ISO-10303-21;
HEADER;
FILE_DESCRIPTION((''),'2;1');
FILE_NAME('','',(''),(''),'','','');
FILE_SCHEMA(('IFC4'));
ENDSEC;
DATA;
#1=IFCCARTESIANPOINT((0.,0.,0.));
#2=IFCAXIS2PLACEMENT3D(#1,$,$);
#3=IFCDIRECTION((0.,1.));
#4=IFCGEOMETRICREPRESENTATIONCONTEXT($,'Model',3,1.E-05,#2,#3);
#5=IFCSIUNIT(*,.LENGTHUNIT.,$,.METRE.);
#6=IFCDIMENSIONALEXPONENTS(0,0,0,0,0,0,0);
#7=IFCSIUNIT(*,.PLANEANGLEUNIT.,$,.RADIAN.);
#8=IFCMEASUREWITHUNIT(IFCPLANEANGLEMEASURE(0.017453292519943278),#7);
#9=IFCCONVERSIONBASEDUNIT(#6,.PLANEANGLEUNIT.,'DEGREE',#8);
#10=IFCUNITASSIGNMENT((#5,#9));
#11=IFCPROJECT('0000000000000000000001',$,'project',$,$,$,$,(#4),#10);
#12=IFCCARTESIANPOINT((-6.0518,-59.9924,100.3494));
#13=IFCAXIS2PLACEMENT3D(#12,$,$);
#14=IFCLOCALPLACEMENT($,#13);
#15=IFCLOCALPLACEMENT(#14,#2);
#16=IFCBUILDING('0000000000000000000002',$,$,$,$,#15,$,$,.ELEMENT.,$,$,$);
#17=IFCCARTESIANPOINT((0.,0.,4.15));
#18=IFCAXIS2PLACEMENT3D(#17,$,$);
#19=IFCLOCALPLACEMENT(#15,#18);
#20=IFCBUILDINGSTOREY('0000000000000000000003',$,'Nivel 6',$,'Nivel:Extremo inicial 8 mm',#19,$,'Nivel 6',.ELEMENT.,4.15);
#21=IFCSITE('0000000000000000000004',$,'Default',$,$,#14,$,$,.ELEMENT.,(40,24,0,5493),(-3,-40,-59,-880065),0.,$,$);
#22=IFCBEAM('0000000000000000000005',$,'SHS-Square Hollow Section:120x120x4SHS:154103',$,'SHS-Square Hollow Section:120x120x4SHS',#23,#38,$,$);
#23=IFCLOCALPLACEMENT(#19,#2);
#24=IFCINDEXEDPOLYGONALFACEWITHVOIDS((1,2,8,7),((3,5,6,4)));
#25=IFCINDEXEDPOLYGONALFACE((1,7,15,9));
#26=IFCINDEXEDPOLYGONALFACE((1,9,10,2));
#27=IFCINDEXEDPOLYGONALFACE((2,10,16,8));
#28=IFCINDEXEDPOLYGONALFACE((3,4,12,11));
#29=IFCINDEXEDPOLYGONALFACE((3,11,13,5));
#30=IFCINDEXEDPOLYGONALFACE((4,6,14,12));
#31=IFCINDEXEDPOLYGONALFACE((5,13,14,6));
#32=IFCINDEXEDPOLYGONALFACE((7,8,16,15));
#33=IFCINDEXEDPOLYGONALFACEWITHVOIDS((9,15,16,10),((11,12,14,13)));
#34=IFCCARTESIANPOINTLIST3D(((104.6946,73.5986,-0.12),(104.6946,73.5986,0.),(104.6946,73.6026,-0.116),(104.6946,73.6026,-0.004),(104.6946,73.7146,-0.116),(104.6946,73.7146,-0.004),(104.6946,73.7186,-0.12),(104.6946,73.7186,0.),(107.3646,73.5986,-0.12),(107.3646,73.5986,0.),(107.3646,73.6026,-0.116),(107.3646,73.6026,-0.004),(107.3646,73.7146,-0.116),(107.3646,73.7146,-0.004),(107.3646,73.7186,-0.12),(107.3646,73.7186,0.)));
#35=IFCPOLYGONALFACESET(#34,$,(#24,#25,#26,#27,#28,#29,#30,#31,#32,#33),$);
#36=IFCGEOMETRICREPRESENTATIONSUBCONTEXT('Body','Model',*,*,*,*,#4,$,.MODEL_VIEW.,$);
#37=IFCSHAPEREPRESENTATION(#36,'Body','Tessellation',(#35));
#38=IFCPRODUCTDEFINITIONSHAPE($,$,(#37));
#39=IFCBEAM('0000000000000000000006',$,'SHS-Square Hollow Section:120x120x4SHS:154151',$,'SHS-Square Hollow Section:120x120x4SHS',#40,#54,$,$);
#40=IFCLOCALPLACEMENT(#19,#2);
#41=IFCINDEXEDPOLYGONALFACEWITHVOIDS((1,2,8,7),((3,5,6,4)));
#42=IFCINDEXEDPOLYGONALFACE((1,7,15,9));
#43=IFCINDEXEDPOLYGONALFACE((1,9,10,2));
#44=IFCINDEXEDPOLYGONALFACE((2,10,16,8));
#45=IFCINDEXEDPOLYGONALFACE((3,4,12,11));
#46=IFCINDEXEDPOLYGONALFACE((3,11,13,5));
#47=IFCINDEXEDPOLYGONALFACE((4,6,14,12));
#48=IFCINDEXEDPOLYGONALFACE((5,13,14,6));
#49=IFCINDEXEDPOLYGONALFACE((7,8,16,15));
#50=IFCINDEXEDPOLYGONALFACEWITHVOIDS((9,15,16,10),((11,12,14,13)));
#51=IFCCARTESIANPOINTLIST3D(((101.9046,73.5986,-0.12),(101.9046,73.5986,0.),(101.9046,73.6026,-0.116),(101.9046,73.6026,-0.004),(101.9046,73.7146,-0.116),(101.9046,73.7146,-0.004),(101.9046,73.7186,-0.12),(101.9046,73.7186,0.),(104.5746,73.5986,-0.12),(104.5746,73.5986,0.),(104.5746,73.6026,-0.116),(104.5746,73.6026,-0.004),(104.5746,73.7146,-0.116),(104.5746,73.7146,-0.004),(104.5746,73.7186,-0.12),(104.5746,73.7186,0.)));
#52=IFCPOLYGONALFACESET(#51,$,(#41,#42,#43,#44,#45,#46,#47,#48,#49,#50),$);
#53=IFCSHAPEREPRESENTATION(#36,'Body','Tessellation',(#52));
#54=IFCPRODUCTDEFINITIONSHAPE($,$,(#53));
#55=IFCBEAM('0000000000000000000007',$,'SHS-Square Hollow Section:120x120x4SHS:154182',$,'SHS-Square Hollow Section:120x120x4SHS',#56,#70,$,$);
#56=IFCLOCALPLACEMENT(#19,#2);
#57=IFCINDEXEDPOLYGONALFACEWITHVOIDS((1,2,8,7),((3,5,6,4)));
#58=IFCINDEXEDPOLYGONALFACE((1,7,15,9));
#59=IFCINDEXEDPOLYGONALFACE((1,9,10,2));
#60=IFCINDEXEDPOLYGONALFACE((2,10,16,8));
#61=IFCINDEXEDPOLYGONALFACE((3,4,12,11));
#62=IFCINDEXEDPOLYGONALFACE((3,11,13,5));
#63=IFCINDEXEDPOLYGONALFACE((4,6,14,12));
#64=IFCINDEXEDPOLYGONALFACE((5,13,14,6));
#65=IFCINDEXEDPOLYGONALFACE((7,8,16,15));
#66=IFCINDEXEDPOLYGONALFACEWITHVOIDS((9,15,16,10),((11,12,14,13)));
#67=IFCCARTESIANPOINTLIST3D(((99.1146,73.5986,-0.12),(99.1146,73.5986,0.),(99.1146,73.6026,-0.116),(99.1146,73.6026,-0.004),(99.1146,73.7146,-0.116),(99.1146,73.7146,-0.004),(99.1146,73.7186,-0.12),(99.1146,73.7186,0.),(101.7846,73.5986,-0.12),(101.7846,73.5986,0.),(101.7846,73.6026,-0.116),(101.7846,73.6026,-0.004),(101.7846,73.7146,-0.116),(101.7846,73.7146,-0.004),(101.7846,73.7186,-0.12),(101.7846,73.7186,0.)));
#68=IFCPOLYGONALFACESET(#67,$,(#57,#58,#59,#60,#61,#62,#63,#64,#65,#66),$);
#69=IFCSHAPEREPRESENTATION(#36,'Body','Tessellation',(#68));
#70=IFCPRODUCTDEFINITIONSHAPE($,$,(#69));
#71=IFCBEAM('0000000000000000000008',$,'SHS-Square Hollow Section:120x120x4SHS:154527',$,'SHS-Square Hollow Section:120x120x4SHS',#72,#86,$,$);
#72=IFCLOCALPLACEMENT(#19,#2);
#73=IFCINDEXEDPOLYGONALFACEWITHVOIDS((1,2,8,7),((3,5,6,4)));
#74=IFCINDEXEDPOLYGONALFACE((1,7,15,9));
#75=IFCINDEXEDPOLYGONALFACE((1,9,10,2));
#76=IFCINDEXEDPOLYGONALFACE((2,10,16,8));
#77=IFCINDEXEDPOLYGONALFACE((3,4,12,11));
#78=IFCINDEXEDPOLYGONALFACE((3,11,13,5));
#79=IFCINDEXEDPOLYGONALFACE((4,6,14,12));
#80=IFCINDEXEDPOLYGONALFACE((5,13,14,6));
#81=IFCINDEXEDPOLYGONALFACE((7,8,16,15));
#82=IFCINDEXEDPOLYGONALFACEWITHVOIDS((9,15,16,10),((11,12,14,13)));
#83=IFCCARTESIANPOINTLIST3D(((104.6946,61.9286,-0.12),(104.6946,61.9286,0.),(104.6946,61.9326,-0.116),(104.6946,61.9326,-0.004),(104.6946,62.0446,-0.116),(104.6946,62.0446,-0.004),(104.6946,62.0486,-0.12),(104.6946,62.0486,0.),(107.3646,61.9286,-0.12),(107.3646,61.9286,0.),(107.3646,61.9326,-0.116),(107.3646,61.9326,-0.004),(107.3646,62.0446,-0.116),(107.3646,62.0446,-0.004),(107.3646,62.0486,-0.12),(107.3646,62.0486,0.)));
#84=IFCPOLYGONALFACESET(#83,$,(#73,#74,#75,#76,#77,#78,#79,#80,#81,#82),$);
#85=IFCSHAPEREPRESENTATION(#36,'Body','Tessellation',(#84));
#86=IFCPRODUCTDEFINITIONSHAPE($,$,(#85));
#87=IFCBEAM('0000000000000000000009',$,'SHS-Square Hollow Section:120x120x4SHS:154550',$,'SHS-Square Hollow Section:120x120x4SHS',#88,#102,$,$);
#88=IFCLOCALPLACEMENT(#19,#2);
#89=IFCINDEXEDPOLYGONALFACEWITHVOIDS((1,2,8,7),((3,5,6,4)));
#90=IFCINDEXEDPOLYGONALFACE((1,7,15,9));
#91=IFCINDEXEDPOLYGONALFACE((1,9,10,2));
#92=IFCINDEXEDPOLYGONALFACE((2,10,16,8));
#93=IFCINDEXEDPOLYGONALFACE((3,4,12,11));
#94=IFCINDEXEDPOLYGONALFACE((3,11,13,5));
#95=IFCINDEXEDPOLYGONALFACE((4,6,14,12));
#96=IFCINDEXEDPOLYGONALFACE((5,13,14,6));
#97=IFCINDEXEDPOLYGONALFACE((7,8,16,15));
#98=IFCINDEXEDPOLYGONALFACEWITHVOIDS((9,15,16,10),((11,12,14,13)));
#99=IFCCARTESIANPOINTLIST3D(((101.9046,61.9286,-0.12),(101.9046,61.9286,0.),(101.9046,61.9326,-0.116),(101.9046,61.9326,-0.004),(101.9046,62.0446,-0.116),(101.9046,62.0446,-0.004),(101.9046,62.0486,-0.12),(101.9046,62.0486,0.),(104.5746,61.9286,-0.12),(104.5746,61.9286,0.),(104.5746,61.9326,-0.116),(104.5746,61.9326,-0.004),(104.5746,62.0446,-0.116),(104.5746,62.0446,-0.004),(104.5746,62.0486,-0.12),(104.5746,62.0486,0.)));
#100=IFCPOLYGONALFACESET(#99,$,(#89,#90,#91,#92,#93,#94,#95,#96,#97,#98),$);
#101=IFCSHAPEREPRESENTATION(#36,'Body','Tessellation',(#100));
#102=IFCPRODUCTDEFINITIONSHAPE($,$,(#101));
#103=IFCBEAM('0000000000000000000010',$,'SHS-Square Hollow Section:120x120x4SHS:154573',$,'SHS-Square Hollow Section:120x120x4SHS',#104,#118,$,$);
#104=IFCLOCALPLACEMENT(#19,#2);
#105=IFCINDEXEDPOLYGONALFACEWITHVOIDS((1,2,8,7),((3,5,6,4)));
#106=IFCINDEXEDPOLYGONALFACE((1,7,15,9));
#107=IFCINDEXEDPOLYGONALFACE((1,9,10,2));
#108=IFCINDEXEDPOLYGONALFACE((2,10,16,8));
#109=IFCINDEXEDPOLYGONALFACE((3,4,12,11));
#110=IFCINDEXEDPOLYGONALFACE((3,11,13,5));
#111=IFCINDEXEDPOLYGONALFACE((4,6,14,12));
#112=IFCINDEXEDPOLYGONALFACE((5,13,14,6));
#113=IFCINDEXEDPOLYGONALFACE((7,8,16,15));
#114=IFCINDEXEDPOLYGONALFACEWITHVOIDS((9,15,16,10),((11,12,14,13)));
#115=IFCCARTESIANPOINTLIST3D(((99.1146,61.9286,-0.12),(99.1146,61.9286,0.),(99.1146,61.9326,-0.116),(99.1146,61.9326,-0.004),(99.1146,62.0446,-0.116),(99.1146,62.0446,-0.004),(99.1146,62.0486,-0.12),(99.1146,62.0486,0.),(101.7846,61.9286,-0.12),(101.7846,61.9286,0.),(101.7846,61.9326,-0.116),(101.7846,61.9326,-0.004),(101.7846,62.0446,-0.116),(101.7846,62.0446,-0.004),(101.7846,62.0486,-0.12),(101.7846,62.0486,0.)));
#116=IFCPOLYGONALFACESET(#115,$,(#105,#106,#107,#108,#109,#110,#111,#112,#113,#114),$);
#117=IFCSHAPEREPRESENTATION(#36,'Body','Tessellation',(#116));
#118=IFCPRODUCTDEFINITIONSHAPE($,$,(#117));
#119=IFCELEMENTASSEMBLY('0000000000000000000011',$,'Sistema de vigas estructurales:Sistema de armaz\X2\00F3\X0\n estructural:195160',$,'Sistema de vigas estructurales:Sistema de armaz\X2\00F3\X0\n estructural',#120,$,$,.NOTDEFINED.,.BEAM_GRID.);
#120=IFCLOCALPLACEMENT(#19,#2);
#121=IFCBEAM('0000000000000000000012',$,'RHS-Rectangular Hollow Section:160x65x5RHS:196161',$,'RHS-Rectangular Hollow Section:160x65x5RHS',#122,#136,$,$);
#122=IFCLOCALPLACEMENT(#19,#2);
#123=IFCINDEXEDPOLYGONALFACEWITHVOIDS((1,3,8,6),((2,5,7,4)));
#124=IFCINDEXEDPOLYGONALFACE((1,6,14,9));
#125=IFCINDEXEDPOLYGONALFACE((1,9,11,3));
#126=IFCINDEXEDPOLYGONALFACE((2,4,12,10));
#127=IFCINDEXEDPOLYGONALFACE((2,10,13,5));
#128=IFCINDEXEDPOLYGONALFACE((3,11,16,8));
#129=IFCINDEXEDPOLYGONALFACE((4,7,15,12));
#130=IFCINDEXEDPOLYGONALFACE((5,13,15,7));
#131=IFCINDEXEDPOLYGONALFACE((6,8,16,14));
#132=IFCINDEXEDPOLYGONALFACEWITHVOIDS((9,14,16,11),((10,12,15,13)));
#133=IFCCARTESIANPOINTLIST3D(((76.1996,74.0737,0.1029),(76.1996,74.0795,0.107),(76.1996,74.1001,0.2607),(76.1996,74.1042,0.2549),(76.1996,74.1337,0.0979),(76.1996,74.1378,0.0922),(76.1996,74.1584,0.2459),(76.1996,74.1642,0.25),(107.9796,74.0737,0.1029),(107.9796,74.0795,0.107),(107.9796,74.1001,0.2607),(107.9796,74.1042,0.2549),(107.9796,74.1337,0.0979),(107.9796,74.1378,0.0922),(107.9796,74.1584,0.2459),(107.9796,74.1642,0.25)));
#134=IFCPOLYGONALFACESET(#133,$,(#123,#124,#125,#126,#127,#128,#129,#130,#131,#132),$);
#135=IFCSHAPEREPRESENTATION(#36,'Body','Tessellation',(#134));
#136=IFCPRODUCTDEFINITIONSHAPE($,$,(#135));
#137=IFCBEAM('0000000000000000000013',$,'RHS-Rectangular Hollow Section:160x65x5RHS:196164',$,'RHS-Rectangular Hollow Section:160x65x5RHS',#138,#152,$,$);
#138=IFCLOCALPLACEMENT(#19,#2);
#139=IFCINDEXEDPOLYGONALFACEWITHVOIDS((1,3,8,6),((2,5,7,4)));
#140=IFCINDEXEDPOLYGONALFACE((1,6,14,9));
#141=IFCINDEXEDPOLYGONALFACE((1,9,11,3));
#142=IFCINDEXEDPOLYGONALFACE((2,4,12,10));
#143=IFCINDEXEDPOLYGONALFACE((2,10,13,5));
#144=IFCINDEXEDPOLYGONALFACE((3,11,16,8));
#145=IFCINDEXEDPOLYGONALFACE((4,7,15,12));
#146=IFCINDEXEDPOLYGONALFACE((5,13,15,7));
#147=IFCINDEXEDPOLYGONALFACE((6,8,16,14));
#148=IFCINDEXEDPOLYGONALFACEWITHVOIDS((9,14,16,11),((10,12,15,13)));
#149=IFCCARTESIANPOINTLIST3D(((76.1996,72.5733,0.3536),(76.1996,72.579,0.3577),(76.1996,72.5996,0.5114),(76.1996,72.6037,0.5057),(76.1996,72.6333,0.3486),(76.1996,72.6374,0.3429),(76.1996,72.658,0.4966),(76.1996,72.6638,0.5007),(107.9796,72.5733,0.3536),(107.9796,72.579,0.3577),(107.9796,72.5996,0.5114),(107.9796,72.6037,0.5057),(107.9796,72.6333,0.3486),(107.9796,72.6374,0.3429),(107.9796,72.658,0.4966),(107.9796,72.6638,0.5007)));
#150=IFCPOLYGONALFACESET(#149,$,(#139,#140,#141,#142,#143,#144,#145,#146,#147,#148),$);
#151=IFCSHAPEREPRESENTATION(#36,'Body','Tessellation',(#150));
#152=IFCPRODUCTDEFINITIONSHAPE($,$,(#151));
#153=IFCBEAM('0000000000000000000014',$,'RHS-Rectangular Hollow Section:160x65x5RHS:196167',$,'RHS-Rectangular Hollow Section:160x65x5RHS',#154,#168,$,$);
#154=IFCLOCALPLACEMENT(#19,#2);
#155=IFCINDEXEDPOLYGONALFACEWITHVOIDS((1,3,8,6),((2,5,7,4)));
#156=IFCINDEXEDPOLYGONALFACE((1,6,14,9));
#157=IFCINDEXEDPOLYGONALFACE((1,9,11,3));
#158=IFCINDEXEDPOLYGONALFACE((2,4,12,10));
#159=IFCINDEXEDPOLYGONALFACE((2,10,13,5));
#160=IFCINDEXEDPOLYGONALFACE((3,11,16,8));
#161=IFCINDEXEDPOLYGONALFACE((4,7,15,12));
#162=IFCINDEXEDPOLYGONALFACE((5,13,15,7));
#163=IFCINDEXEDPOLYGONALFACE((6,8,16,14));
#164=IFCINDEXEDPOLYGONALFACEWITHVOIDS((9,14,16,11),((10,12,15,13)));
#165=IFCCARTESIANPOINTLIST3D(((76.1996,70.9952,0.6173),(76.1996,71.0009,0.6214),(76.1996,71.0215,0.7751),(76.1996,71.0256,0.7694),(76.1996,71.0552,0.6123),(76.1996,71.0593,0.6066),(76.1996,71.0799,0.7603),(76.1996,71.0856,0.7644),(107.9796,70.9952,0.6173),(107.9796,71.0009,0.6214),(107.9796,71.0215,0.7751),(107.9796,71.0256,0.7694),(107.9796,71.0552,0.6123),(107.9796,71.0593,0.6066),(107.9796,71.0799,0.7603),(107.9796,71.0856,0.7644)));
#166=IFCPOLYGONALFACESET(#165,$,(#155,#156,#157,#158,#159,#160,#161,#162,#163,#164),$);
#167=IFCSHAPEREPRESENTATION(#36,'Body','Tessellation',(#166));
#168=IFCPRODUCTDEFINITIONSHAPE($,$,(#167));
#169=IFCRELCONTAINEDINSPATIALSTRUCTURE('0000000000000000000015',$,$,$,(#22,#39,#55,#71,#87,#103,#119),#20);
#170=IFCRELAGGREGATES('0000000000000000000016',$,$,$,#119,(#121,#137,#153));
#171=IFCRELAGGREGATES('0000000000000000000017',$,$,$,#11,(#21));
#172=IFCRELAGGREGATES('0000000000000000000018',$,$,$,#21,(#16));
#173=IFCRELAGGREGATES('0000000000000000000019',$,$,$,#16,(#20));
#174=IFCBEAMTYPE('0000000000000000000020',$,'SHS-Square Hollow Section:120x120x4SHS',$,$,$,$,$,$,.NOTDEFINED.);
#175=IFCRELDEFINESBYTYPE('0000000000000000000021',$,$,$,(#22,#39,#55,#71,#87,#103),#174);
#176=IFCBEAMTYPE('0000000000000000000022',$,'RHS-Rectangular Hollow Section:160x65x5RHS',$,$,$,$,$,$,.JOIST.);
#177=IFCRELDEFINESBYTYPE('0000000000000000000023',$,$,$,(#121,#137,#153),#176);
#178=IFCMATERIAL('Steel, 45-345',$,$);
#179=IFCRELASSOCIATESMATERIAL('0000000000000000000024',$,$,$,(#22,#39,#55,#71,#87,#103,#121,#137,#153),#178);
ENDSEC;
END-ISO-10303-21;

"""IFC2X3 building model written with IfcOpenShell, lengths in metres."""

from ifc_helpers import new_model, entity, si_unit, converted_unit, direction, frame, frame_2d, origin, place, context, subcontext, project, spatial, rectangle, extrude, boolean, material, type_object, element, aggregate, save


model = new_model("IFC2X3")

# Units and contexts
model_context = context("Model", 3, precision=1e-05, world=origin(), true_north=direction((0.0, 1.0)))
body_context = subcontext(model_context, "Body", "Model", "MODEL_VIEW")
ifc_project = project(units=[si_unit("LENGTHUNIT", "METRE"), converted_unit("PLANEANGLEUNIT", "DEGREE", entity("IfcPlaneAngleMeasure", 0.017453292519943278), si_unit("PLANEANGLEUNIT", "RADIAN"), dimensions=[0, 0, 0, 0, 0, 0, 0])], contexts=[model_context])

# Site, building, storey
site_placement = place(None, frame((-6.0518, -59.9924, 100.3494)))
site = spatial("IfcSite", under=ifc_project, at=site_placement, Name="Default", CompositionType="ELEMENT", RefLatitude=(40, 24, 0, 5493), RefLongitude=(-3, -40, -59, -880065), RefElevation=0.0)
building_placement = place(site_placement, origin())
building = spatial("IfcBuilding", under=site, at=building_placement, CompositionType="ELEMENT")
storey_placement = place(building_placement, frame((0.0, 0.0, 4.15)))
storey = spatial("IfcBuildingStorey", under=building, at=storey_placement, Name="Nivel 6", ObjectType="Nivel:Extremo inicial 8 mm", LongName="Nivel 6", CompositionType="ELEMENT", Elevation=4.15)

# Beams
ifc_material_1 = material(Name="Steel, 45-345")
beam_type_1 = type_object("IfcBeamType", Name="SHS-Square Hollow Section:120x120x4SHS", PredefinedType="NOTDEFINED")
beam_1_placement = place(storey_placement, frame((107.3646, 73.6586, 0.0), z_axis=(0.0, 0.0, 1.0), x_axis=(-1.0, 0.0, 0.0)))
element("IfcBeam", 1, at=beam_1_placement, inside=storey, type_object=beam_type_1, material=ifc_material_1, Name="SHS-Square Hollow Section:120x120x4SHS:154103", ObjectType="SHS-Square Hollow Section:120x120x4SHS", context=body_context, shape_type="SweptSolid", body=[
    boolean("DIFFERENCE", extrude(rectangle(XDim=0.12, YDim=0.12, at=frame_2d((0.0, 0.0), x_axis=(1.0, 0.0))), frame((0.0, 0.0, -0.06), z_axis=(1.0, 0.0, 0.0), x_axis=(0.0, 0.0, -1.0)), (0.0, 0.0, 1.0), 2.67), extrude(rectangle(XDim=0.112, YDim=0.112, at=frame_2d((0.0, 0.0), x_axis=(0.0, 1.0))), frame((2.67, 0.0, -0.06), z_axis=(-1.0, 0.0, 0.0), x_axis=(0.0, 1.0, 0.0)), (0.0, 0.0, 1.0), 2.67)),
])
beam_2_placement = place(storey_placement, frame((104.5746, 73.6586, 0.0), z_axis=(0.0, 0.0, 1.0), x_axis=(-1.0, 0.0, 0.0)))
element("IfcBeam", 2, at=beam_2_placement, inside=storey, type_object=beam_type_1, material=ifc_material_1, Name="SHS-Square Hollow Section:120x120x4SHS:154151", ObjectType="SHS-Square Hollow Section:120x120x4SHS", context=body_context, shape_type="SweptSolid", body=[
    boolean("DIFFERENCE", extrude(rectangle(XDim=0.12, YDim=0.12, at=frame_2d((0.0, 0.0), x_axis=(1.0, 0.0))), frame((0.0, 0.0, -0.06), z_axis=(1.0, 0.0, 0.0), x_axis=(0.0, 0.0, -1.0)), (0.0, 0.0, 1.0), 2.67), extrude(rectangle(XDim=0.112, YDim=0.112, at=frame_2d((0.0, 0.0), x_axis=(0.0, 1.0))), frame((2.67, 0.0, -0.06), z_axis=(-1.0, 0.0, 0.0), x_axis=(0.0, 1.0, 0.0)), (0.0, 0.0, 1.0), 2.67)),
])
beam_3_placement = place(storey_placement, frame((101.8446, 73.6586, 0.0), z_axis=(0.0, 0.0, 1.0), x_axis=(-1.0, 0.0, 0.0)))
element("IfcBeam", 3, at=beam_3_placement, inside=storey, type_object=beam_type_1, material=ifc_material_1, Name="SHS-Square Hollow Section:120x120x4SHS:154182", ObjectType="SHS-Square Hollow Section:120x120x4SHS", context=body_context, shape_type="SweptSolid", body=[
    boolean("DIFFERENCE", extrude(rectangle(XDim=0.12, YDim=0.12, at=frame_2d((0.0, 0.0), x_axis=(1.0, 0.0))), frame((0.06, 0.0, -0.06), z_axis=(1.0, 0.0, 0.0), x_axis=(0.0, 0.0, -1.0)), (0.0, 0.0, 1.0), 2.67), extrude(rectangle(XDim=0.112, YDim=0.112, at=frame_2d((0.0, 0.0), x_axis=(0.0, 1.0))), frame((2.73, 0.0, -0.06), z_axis=(-1.0, 0.0, 0.0), x_axis=(0.0, 1.0, 0.0)), (0.0, 0.0, 1.0), 2.67)),
])
beam_4_placement = place(storey_placement, frame((107.4246, 61.9886, 0.0), z_axis=(0.0, 0.0, 1.0), x_axis=(-1.0, 0.0, 0.0)))
element("IfcBeam", 4, at=beam_4_placement, inside=storey, type_object=beam_type_1, material=ifc_material_1, Name="SHS-Square Hollow Section:120x120x4SHS:154527", ObjectType="SHS-Square Hollow Section:120x120x4SHS", context=body_context, shape_type="SweptSolid", body=[
    boolean("DIFFERENCE", extrude(rectangle(XDim=0.12, YDim=0.12, at=frame_2d((0.0, 0.0), x_axis=(1.0, 0.0))), frame((0.06, 0.0, -0.06), z_axis=(1.0, 0.0, 0.0), x_axis=(0.0, 0.0, -1.0)), (0.0, 0.0, 1.0), 2.67), extrude(rectangle(XDim=0.112, YDim=0.112, at=frame_2d((0.0, 0.0), x_axis=(0.0, 1.0))), frame((2.73, 0.0, -0.06), z_axis=(-1.0, 0.0, 0.0), x_axis=(0.0, 1.0, 0.0)), (0.0, 0.0, 1.0), 2.67)),
])
beam_5_placement = place(storey_placement, frame((104.6346, 61.9886, 0.0), z_axis=(0.0, 0.0, 1.0), x_axis=(-1.0, 0.0, 0.0)))
element("IfcBeam", 5, at=beam_5_placement, inside=storey, type_object=beam_type_1, material=ifc_material_1, Name="SHS-Square Hollow Section:120x120x4SHS:154550", ObjectType="SHS-Square Hollow Section:120x120x4SHS", context=body_context, shape_type="SweptSolid", body=[
    boolean("DIFFERENCE", extrude(rectangle(XDim=0.12, YDim=0.12, at=frame_2d((0.0, 0.0), x_axis=(1.0, 0.0))), frame((0.06, 0.0, -0.06), z_axis=(1.0, 0.0, 0.0), x_axis=(0.0, 0.0, -1.0)), (0.0, 0.0, 1.0), 2.67), extrude(rectangle(XDim=0.112, YDim=0.112, at=frame_2d((0.0, 0.0), x_axis=(0.0, 1.0))), frame((2.73, 0.0, -0.06), z_axis=(-1.0, 0.0, 0.0), x_axis=(0.0, 1.0, 0.0)), (0.0, 0.0, 1.0), 2.67)),
])
beam_6_placement = place(storey_placement, frame((101.8446, 61.9886, 0.0), z_axis=(0.0, 0.0, 1.0), x_axis=(-1.0, 0.0, 0.0)))
element("IfcBeam", 6, at=beam_6_placement, inside=storey, type_object=beam_type_1, material=ifc_material_1, Name="SHS-Square Hollow Section:120x120x4SHS:154573", ObjectType="SHS-Square Hollow Section:120x120x4SHS", context=body_context, shape_type="SweptSolid", body=[
    boolean("DIFFERENCE", extrude(rectangle(XDim=0.12, YDim=0.12, at=frame_2d((0.0, 0.0), x_axis=(1.0, 0.0))), frame((0.06, 0.0, -0.06), z_axis=(1.0, 0.0, 0.0), x_axis=(0.0, 0.0, -1.0)), (0.0, 0.0, 1.0), 2.67), extrude(rectangle(XDim=0.112, YDim=0.112, at=frame_2d((0.0, 0.0), x_axis=(0.0, 1.0))), frame((2.73, 0.0, -0.06), z_axis=(-1.0, 0.0, 0.0), x_axis=(0.0, 1.0, 0.0)), (0.0, 0.0, 1.0), 2.67)),
])

# Element assembly, beams
assembly_placement = place(storey_placement, origin())
assembly = element("IfcElementAssembly", 7, at=assembly_placement, inside=storey, Name="Sistema de vigas estructurales:Sistema de armazón estructural:195160", ObjectType="Sistema de vigas estructurales:Sistema de armazón estructural", AssemblyPlace="NOTDEFINED", PredefinedType="BEAM_GRID")
beam_type_2 = type_object("IfcBeamType", Name="RHS-Rectangular Hollow Section:160x65x5RHS", PredefinedType="JOIST")
beam_7_placement = place(assembly_placement, frame((107.9796, 74.0794, -0.0603), z_axis=(0.0, 0.0, 1.0), x_axis=(-1.0, 0.0, 0.0)))
beam_7 = element("IfcBeam", 8, at=beam_7_placement, type_object=beam_type_2, material=ifc_material_1, Name="RHS-Rectangular Hollow Section:160x65x5RHS:196161", ObjectType="RHS-Rectangular Hollow Section:160x65x5RHS", context=body_context, shape_type="SweptSolid", body=[
    boolean("DIFFERENCE", extrude(rectangle(XDim=0.16, YDim=0.065, at=frame_2d((0.0, 0.0), x_axis=(0.0, 1.0))), frame((0.0, -0.0396, 0.2367), z_axis=(1.0, 0.0, 0.0), x_axis=(0.0, -0.986325, -0.16481)), (0.0, 0.0, 1.0), 31.78), extrude(rectangle(XDim=0.15, YDim=0.055, at=frame_2d((0.0, 0.0), x_axis=(0.0, 1.0))), frame((31.78, -0.0396, 0.2367), z_axis=(-1.0, 0.0, 0.0), x_axis=(0.0, 0.986325, 0.16481)), (0.0, 0.0, 1.0), 31.78)),
])
beam_8_placement = place(assembly_placement, frame((107.9796, 72.579, 0.1904), z_axis=(0.0, 0.0, 1.0), x_axis=(-1.0, 0.0, 0.0)))
beam_8 = element("IfcBeam", 9, at=beam_8_placement, type_object=beam_type_2, material=ifc_material_1, Name="RHS-Rectangular Hollow Section:160x65x5RHS:196164", ObjectType="RHS-Rectangular Hollow Section:160x65x5RHS", context=body_context, shape_type="SweptSolid", body=[
    boolean("DIFFERENCE", extrude(rectangle(XDim=0.16, YDim=0.065, at=frame_2d((0.0, 0.0), x_axis=(0.0, 1.0))), frame((0.0, -0.0396, 0.2367), z_axis=(1.0, 0.0, 0.0), x_axis=(0.0, -0.986325, -0.16481)), (0.0, 0.0, 1.0), 31.78), extrude(rectangle(XDim=0.15, YDim=0.055, at=frame_2d((0.0, 0.0), x_axis=(0.0, 1.0))), frame((31.78, -0.0396, 0.2367), z_axis=(-1.0, 0.0, 0.0), x_axis=(0.0, 0.986325, 0.16481)), (0.0, 0.0, 1.0), 31.78)),
])
beam_9_placement = place(assembly_placement, frame((107.9796, 71.0008, 0.4541), z_axis=(0.0, 0.0, 1.0), x_axis=(-1.0, 0.0, 0.0)))
beam_9 = element("IfcBeam", 10, at=beam_9_placement, type_object=beam_type_2, material=ifc_material_1, Name="RHS-Rectangular Hollow Section:160x65x5RHS:196167", ObjectType="RHS-Rectangular Hollow Section:160x65x5RHS", context=body_context, shape_type="SweptSolid", body=[
    boolean("DIFFERENCE", extrude(rectangle(XDim=0.16, YDim=0.065, at=frame_2d((0.0, 0.0), x_axis=(0.0, 1.0))), frame((0.0, -0.0396, 0.2367), z_axis=(1.0, 0.0, 0.0), x_axis=(0.0, -0.986325, -0.16481)), (0.0, 0.0, 1.0), 31.78), extrude(rectangle(XDim=0.15, YDim=0.055, at=frame_2d((0.0, 0.0), x_axis=(0.0, 1.0))), frame((31.78, -0.0396, 0.2367), z_axis=(-1.0, 0.0, 0.0), x_axis=(0.0, 0.986325, 0.16481)), (0.0, 0.0, 1.0), 31.78)),
])
aggregate(assembly, [beam_7, beam_8, beam_9])

save(model, "model.ifc")
